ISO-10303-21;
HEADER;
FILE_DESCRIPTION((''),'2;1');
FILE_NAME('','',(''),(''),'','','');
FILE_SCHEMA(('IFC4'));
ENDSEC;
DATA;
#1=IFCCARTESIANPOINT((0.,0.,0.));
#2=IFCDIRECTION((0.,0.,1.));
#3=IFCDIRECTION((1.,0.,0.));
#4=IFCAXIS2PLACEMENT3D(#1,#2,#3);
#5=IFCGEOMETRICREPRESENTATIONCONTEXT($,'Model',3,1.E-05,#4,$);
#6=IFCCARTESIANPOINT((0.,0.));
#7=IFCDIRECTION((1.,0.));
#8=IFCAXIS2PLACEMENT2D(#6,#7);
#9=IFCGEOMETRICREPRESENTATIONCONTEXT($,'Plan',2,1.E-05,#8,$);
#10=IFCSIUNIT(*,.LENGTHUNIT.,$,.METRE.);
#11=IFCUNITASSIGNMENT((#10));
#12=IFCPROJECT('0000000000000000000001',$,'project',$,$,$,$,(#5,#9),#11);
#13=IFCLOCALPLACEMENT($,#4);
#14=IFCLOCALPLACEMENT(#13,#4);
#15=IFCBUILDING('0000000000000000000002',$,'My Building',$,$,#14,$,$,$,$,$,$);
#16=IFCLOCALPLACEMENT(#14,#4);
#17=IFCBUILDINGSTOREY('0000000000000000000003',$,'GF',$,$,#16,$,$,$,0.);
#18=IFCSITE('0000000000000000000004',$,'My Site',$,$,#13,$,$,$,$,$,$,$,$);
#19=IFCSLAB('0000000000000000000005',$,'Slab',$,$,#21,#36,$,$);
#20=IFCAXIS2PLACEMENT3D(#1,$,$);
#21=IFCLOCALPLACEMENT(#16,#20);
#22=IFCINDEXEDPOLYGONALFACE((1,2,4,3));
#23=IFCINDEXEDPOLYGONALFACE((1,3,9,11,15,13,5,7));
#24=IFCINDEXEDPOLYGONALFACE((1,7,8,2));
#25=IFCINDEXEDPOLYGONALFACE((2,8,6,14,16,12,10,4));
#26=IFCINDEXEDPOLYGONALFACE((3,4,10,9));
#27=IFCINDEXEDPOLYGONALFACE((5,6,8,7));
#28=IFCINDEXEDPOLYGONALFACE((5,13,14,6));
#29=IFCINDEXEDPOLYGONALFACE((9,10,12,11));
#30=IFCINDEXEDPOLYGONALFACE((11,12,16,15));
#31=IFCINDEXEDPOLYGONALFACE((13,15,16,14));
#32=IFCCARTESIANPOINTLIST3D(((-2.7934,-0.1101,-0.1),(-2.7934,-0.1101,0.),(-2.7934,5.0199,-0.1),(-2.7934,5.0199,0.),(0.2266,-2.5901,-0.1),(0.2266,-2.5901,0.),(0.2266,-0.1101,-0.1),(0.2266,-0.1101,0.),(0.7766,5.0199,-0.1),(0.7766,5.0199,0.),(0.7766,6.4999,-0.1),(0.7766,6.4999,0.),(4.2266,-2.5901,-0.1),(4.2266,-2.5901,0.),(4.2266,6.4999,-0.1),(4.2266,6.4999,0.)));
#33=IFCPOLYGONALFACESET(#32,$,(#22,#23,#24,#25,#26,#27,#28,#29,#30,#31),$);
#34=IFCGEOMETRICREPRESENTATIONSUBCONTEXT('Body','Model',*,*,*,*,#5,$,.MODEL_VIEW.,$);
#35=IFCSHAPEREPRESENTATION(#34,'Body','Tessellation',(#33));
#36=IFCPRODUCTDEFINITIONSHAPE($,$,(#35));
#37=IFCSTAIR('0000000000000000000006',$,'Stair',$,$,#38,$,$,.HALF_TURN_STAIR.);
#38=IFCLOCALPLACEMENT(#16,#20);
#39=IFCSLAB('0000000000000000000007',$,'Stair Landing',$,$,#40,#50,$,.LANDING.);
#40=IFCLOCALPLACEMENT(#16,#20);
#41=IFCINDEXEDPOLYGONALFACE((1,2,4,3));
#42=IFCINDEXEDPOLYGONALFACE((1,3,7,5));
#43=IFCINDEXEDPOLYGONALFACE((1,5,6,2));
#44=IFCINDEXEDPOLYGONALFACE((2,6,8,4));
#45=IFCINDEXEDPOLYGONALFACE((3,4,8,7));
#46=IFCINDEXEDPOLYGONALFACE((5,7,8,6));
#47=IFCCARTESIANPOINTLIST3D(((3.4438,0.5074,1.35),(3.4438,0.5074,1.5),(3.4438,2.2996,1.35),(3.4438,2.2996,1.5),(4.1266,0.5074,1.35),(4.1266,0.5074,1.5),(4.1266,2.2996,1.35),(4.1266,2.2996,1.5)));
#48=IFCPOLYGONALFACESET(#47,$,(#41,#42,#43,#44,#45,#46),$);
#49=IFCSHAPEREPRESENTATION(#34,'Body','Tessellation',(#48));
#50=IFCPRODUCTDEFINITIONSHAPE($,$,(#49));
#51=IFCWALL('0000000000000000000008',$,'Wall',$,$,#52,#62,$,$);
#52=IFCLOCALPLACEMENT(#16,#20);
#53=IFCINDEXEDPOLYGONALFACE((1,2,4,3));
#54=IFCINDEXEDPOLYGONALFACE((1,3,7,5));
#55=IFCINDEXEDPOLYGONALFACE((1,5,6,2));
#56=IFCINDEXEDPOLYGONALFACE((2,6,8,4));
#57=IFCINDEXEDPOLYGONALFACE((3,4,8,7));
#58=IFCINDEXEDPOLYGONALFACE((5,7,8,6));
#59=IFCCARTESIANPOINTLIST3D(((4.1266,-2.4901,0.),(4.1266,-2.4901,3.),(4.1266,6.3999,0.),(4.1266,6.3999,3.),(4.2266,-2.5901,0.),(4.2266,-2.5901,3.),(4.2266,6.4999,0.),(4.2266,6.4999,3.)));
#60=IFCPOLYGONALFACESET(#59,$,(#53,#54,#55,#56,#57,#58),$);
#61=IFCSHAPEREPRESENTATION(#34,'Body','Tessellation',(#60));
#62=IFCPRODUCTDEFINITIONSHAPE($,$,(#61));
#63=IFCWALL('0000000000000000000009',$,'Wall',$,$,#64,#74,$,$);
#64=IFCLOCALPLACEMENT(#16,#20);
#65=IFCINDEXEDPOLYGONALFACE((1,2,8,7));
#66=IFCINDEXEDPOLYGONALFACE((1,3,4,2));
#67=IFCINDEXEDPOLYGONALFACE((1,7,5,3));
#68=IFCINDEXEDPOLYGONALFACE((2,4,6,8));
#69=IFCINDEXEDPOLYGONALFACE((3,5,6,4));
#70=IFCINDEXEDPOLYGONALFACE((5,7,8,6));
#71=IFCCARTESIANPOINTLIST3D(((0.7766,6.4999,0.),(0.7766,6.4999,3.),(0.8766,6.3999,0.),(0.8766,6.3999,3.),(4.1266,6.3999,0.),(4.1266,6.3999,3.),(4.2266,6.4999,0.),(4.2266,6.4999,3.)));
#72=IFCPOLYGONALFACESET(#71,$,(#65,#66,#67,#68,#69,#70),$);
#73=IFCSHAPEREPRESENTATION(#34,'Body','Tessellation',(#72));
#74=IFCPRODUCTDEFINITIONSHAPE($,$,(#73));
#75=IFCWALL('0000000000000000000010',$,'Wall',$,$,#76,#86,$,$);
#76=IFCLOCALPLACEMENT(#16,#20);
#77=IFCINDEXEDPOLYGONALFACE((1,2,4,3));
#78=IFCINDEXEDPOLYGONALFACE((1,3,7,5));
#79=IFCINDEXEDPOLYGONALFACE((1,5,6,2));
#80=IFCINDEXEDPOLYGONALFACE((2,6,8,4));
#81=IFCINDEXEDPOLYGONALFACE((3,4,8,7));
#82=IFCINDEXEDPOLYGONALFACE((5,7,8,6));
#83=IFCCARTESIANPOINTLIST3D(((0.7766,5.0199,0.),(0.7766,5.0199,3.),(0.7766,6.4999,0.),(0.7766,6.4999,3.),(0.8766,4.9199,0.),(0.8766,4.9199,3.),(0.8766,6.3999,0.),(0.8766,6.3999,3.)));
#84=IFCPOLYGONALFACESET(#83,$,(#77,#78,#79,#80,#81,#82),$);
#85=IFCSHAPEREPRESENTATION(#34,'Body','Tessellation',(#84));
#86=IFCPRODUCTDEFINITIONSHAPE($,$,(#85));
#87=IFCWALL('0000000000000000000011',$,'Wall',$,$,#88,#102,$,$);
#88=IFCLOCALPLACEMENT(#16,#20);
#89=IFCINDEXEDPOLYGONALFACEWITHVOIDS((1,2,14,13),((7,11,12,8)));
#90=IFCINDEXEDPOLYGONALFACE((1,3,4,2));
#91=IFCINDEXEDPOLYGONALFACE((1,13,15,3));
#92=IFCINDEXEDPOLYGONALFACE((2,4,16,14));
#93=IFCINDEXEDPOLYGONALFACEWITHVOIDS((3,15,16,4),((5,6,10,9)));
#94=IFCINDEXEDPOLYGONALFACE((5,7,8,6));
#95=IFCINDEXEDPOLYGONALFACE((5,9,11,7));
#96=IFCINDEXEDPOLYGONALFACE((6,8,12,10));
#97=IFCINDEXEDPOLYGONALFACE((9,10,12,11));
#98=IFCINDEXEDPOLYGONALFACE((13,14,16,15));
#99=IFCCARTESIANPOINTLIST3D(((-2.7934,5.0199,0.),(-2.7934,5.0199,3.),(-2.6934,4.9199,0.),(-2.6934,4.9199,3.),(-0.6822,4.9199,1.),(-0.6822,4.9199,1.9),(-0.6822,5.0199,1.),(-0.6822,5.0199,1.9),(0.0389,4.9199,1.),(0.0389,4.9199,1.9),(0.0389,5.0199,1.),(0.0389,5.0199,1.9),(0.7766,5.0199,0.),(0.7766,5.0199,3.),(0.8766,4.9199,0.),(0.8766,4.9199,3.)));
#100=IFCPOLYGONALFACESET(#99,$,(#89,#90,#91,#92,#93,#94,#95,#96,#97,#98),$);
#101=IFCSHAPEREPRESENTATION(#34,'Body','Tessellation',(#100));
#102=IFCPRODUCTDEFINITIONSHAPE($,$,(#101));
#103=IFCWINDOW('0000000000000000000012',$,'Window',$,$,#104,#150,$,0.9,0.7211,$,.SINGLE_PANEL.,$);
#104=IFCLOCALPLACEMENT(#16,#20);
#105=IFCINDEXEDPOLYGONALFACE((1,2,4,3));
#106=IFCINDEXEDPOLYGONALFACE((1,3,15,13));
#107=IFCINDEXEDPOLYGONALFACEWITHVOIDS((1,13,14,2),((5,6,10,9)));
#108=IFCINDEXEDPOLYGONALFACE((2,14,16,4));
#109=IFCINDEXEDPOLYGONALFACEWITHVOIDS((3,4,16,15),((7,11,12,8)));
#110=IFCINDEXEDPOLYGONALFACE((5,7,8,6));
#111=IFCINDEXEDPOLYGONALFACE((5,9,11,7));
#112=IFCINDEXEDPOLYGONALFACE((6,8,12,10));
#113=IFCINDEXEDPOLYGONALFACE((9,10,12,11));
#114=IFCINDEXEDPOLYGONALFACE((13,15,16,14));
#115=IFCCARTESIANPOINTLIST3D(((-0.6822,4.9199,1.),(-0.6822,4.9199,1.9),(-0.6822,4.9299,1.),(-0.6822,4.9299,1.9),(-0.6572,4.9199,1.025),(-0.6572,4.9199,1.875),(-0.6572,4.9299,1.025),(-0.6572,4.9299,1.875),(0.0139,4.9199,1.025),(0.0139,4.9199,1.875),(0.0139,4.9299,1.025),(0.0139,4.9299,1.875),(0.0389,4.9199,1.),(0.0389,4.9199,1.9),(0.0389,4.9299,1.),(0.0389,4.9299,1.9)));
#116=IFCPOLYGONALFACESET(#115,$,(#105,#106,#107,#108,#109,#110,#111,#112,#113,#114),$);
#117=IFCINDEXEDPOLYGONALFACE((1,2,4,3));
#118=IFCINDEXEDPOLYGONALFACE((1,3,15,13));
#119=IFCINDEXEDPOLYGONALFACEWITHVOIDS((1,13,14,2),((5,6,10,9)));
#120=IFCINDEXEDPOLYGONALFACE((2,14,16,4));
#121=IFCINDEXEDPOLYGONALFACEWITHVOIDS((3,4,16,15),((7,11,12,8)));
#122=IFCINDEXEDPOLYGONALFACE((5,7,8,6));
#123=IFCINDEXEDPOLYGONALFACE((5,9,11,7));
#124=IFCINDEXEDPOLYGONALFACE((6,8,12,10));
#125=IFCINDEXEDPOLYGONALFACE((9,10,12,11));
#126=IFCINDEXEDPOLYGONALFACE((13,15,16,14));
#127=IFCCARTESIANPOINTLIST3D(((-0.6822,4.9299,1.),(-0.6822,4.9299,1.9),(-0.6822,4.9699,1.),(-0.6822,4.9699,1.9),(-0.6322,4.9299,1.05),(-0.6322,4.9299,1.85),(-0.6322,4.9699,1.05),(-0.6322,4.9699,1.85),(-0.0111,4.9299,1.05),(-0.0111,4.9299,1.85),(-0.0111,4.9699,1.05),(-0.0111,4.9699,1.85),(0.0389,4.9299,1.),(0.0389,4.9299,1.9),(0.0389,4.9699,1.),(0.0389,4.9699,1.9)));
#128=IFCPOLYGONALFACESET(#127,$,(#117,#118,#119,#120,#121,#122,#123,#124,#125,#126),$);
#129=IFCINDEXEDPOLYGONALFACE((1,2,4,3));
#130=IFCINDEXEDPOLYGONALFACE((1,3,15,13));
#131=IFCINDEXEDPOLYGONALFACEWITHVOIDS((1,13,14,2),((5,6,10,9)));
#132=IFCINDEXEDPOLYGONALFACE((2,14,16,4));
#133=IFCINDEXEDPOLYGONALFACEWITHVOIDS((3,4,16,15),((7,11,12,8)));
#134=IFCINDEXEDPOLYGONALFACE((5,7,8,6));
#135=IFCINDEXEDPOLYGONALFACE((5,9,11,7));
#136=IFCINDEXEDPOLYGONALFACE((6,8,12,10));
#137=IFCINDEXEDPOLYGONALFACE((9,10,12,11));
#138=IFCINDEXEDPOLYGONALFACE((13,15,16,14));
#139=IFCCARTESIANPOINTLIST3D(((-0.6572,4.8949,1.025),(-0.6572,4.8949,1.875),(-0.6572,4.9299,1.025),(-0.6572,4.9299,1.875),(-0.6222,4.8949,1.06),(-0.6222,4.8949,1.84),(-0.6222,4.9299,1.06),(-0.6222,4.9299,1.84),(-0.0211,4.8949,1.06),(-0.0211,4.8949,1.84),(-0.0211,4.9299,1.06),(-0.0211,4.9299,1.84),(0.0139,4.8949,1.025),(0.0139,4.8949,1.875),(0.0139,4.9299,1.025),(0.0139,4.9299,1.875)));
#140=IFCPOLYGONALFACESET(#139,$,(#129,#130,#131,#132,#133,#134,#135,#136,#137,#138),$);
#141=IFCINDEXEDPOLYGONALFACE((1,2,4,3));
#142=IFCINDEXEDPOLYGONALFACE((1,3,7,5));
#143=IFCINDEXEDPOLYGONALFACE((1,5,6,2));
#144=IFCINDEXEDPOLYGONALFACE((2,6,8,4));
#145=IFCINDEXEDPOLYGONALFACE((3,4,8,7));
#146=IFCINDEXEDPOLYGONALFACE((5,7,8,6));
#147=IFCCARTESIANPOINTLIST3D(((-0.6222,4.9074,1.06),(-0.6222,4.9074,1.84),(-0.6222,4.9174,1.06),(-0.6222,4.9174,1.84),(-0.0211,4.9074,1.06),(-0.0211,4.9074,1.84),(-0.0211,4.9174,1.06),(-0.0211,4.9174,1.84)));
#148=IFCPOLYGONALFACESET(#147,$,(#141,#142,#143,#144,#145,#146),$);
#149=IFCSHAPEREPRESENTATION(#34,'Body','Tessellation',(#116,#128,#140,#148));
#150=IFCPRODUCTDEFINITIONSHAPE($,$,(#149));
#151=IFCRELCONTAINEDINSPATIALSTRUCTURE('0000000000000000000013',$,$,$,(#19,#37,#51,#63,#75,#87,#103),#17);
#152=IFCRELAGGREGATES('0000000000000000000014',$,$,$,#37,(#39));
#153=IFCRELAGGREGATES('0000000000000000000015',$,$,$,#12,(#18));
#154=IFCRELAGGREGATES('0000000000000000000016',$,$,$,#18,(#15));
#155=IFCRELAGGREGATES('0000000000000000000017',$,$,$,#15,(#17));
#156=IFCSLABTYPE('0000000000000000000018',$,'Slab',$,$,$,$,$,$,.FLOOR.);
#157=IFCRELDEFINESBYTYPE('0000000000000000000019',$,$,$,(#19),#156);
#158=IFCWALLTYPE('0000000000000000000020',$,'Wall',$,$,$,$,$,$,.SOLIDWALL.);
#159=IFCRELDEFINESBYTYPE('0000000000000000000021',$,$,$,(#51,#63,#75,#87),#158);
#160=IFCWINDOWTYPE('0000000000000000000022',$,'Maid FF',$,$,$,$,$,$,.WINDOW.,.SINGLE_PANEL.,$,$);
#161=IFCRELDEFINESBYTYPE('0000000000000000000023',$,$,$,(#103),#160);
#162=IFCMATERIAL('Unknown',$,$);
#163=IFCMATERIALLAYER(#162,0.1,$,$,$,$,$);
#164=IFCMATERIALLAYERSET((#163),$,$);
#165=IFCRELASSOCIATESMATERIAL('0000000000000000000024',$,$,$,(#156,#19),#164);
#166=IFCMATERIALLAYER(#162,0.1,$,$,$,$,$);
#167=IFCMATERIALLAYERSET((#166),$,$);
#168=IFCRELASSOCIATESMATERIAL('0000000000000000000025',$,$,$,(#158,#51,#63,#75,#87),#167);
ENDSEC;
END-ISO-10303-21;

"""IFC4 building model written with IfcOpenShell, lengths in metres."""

from ifc_helpers import new_model, entity, si_unit, frame, origin_with_axes, origin_2d_with_axis, place, context, subcontext, project, spatial, polyline, line, indexed_curve, outline, extrude, shape, source, transform, mapped, material, layer, layer_set, layer_usage, type_object, type_shapes, element, fill, aggregate, save


model = new_model("IFC4")

# Units and contexts
model_context = context("Model", 3, precision=1e-05, world=origin_with_axes())
plan_context = context("Plan", 2, precision=1e-05, world=origin_2d_with_axis())
body_context_1 = subcontext(model_context, "Body", "Model", "MODEL_VIEW")
body_context_2 = subcontext(plan_context, "Body", "Plan", "PLAN_VIEW")
ifc_project = project(units=[si_unit("LENGTHUNIT", "METRE")], contexts=[model_context, plan_context])

# Site, building, storey
site_placement = place(None, origin_with_axes())
site = spatial("IfcSite", under=ifc_project, at=site_placement, Name="My Site")
building_placement = place(site_placement, origin_with_axes())
building = spatial("IfcBuilding", under=site, at=building_placement, Name="My Building")
storey_placement = place(building_placement, origin_with_axes())
storey = spatial("IfcBuildingStorey", under=building, at=storey_placement, Name="GF", Elevation=0.0)

# Slab
ifc_material = material(Name="Unknown")
ifc_layer_1 = layer(ifc_material, 0.1)
ifc_layer_set_1 = layer_set([ifc_layer_1])
ifc_layer_usage_1 = layer_usage(ifc_layer_set_1, "AXIS3", "POSITIVE", -0.1)
slab_type = type_object("IfcSlabType", Name="Slab", PredefinedType="FLOOR", material=ifc_layer_set_1)
slab_1_placement = place(storey_placement, frame((4.2266, -2.5901, 0.0), z_axis=(0.0, 0.0, 1.0), x_axis=(1.0, 0.0, 0.0)))
element("IfcSlab", 1, at=slab_1_placement, inside=storey, type_object=slab_type, material=ifc_layer_usage_1, Name="Slab", context=body_context_1, shape_type="SweptSolid", body=[
    extrude(outline(indexed_curve([(0.0, 0.0), (0.0, 9.09), (-3.45, 9.09), (-3.45, 7.61), (-7.02, 7.61), (-7.02, 2.48), (-4.0, 2.48), (-4.0, 0.0), (0.0, 0.0)])), frame((0.0, 0.0, -0.1), z_axis=(0.0, 0.0, 1.0), x_axis=(1.0, 0.0, 0.0)), (0.0, 0.0, 1.0), 0.1),
])

# Stair, slab
stair_placement = place(storey_placement, origin_with_axes())
stair = element("IfcStair", 2, at=stair_placement, inside=storey, Name="Stair", PredefinedType="HALF_TURN_STAIR")
slab_2_placement = place(stair_placement, frame((0.0, 0.0, 1.5), z_axis=(0.0, 0.0, 1.0), x_axis=(1.0, 0.0, 0.0)))
slab_2 = element("IfcSlab", 3, at=slab_2_placement, Name="Stair Landing", PredefinedType="LANDING", context=body_context_1, shape_type="SweptSolid", body=[
    extrude(outline(polyline([(3.4438, 0.5074), (4.1266, 0.5074), (4.1266, 2.2996), (3.4438, 2.2996), (3.4438, 0.5074)])), frame((0.0, 0.0, -0.15), z_axis=(0.0, 0.0, 1.0), x_axis=(1.0, 0.0, 0.0)), (0.0, 0.0, 1.0), 0.15),
])

# Shared definitions
ifc_layer_2 = layer(ifc_material, 0.1)
ifc_layer_set_2 = layer_set([ifc_layer_2])
wall_type = type_object("IfcWallType", Name="Wall", PredefinedType="SOLIDWALL", material=ifc_layer_set_2)

# Walls
ifc_layer_usage_2 = layer_usage(ifc_layer_set_2, "AXIS2", "POSITIVE", 0.0)
wall_1_placement = place(storey_placement, frame((4.2266, -2.5901, 0.0), z_axis=(0.0, 0.0, 1.0), x_axis=(0.0, 1.0, 0.0)))
element("IfcWall", 4, at=wall_1_placement, inside=storey, type_object=wall_type, material=ifc_layer_usage_2, Name="Wall", context=body_context_1, shape_type="SweptSolid", body=[
    extrude(outline(indexed_curve([(0.0, 0.0), (0.1, 0.1), (8.99, 0.1), (9.09, 0.0)], segments=[line(1, 2, 3, 4, 1)])), origin_with_axes(), (0.0, 0.0, 1.0), 3.0),
])
ifc_layer_usage_3 = layer_usage(ifc_layer_set_2, "AXIS2", "POSITIVE", 0.0)
wall_2_placement = place(storey_placement, frame((4.2266, 6.4999, 0.0), z_axis=(0.0, 0.0, 1.0), x_axis=(-1.0, 0.0, 0.0)))
element("IfcWall", 5, at=wall_2_placement, inside=storey, type_object=wall_type, material=ifc_layer_usage_3, Name="Wall", context=body_context_1, shape_type="SweptSolid", body=[
    extrude(outline(indexed_curve([(0.0, 0.0), (0.1, 0.1), (3.35, 0.1), (3.45, 0.0)], segments=[line(1, 2, 3, 4, 1)])), origin_with_axes(), (0.0, 0.0, 1.0), 3.0),
])
ifc_layer_usage_4 = layer_usage(ifc_layer_set_2, "AXIS2", "POSITIVE", 0.0)
wall_3_placement = place(storey_placement, frame((0.7766, 6.4999, 0.0), z_axis=(0.0, 0.0, 1.0), x_axis=(0.0, -1.0, 0.0)))
element("IfcWall", 6, at=wall_3_placement, inside=storey, type_object=wall_type, material=ifc_layer_usage_4, Name="Wall", context=body_context_1, shape_type="SweptSolid", body=[
    extrude(outline(indexed_curve([(0.0, 0.0), (0.1, 0.1), (1.58, 0.1), (1.48, 0.0)], segments=[line(1, 2, 3, 4, 1)])), origin_with_axes(), (0.0, 0.0, 1.0), 3.0),
])

# Wall, opening, window
ifc_layer_usage_5 = layer_usage(ifc_layer_set_2, "AXIS2", "POSITIVE", 0.0)
wall_4_placement = place(storey_placement, frame((0.7766, 5.0199, 0.0), z_axis=(0.0, 0.0, 1.0), x_axis=(-1.0, 0.0, 0.0)))
wall_4 = element("IfcWall", 7, at=wall_4_placement, inside=storey, type_object=wall_type, material=ifc_layer_usage_5, Name="Wall", context=body_context_1, shape_type="SweptSolid", body=[
    extrude(outline(indexed_curve([(0.0, 0.0), (-0.1, 0.1), (3.47, 0.1), (3.57, 0.0)], segments=[line(1, 2, 3, 4, 1)])), origin_with_axes(), (0.0, 0.0, 1.0), 3.0),
])
shared_shape_1 = source(origin_with_axes(), body_context_1, "Body", "SweptSolid", [
    extrude(outline(indexed_curve([(0.0, 0.0), (0.7211, 0.0), (0.7211, 0.9), (0.0, 0.9)], segments=[line(1, 2, 3, 4, 1)])), frame((0.0, -0.6, 0.0), z_axis=(0.0, -1.0, 0.0), x_axis=(1.0, 0.0, 0.0)), (0.0, 0.0, -1.0), 1.2),
])
opening_1_placement = place(wall_4_placement, frame((0.7377, 0.0, 1.0), z_axis=(0.0, 0.0, 1.0), x_axis=(1.0, 0.0, 0.0)))
opening_1 = element("IfcOpeningElement", 8, at=opening_1_placement, cuts=wall_4, PredefinedType="OPENING", context=body_context_1, shape_type="MappedRepresentation", body=[
    mapped(shared_shape_1, transform((0.0, 0.0, 0.0), x_axis=(1.0, 0.0, 0.0), y_axis=(0.0, 1.0, 0.0), z_axis=(0.0, 0.0, 1.0), scale=1.0)),
])
window_type_1 = type_object("IfcWindowType", Name="Maid FF", PartitioningType="SINGLE_PANEL", PredefinedType="WINDOW")
shared_shape_2 = source(origin_with_axes(), body_context_1, "Body", "SweptSolid", [
    extrude(outline(indexed_curve([(0.0, 0.0), (0.7211, 0.0), (0.7211, 0.9), (0.0, 0.9)], segments=[line(1, 2, 3, 4, 1)]), holes=[indexed_curve([(0.025, 0.025), (0.6961, 0.025), (0.6961, 0.875), (0.025, 0.875)], segments=[line(1, 2, 3, 4, 1)])]), frame((0.0, 0.09, 0.0), z_axis=(0.0, -1.0, 0.0), x_axis=(1.0, 0.0, 0.0)), (0.0, 0.0, -1.0), 0.01),
    extrude(outline(indexed_curve([(0.0, 0.0), (0.7211, 0.0), (0.7211, 0.9), (0.0, 0.9)], segments=[line(1, 2, 3, 4, 1)]), holes=[indexed_curve([(0.05, 0.05), (0.6711, 0.05), (0.6711, 0.85), (0.05, 0.85)], segments=[line(1, 2, 3, 4, 1)])]), frame((0.0, 0.05, 0.0), z_axis=(0.0, -1.0, 0.0), x_axis=(1.0, 0.0, 0.0)), (0.0, 0.0, -1.0), 0.04),
    extrude(outline(indexed_curve([(0.0, 0.0), (0.6711, 0.0), (0.6711, 0.85), (0.0, 0.85)], segments=[line(1, 2, 3, 4, 1)]), holes=[indexed_curve([(0.035, 0.035), (0.6361, 0.035), (0.6361, 0.815), (0.035, 0.815)], segments=[line(1, 2, 3, 4, 1)])]), frame((0.025, 0.09, 0.025), z_axis=(0.0, -1.0, 0.0), x_axis=(1.0, 0.0, 0.0)), (0.0, 0.0, -1.0), 0.035),
    extrude(outline(indexed_curve([(0.035, 0.035), (0.6361, 0.035), (0.6361, 0.815), (0.035, 0.815)], segments=[line(1, 2, 3, 4, 1)])), frame((0.025, 0.1025, 0.025), z_axis=(0.0, -1.0, 0.0), x_axis=(1.0, 0.0, 0.0)), (0.0, 0.0, -1.0), 0.01),
])
shared_shape_3 = source(origin_with_axes(), body_context_2, "Body", "Curve2D", [
    entity("IfcIndexedPolyCurve", entity("IfcCartesianPointList2D", [[0.05, 0.05], [0.6711, 0.05]])),
    entity("IfcIndexedPolyCurve", entity("IfcCartesianPointList2D", [[0.0, 0.1], [0.025, 0.1], [0.025, 0.09], [0.05, 0.09], [0.05, 0.05], [0.0, 0.05]]), [entity("IfcLineIndex", [1, 2, 3, 4, 5, 6, 1])]),
    entity("IfcIndexedPolyCurve", entity("IfcCartesianPointList2D", [[0.7211, 0.1], [0.6961, 0.1], [0.6961, 0.09], [0.6711, 0.09], [0.6711, 0.05], [0.7211, 0.05]]), [entity("IfcLineIndex", [1, 2, 3, 4, 5, 6, 1])]),
    entity("IfcIndexedPolyCurve", entity("IfcCartesianPointList2D", [[0.025, 0.09], [0.06, 0.09], [0.06, 0.125], [0.025, 0.125]]), [entity("IfcLineIndex", [1, 2, 3, 4, 1])]),
    entity("IfcIndexedPolyCurve", entity("IfcCartesianPointList2D", [[0.6961, 0.09], [0.6611, 0.09], [0.6611, 0.125], [0.6961, 0.125]]), [entity("IfcLineIndex", [1, 2, 3, 4, 1])]),
    entity("IfcIndexedPolyCurve", entity("IfcCartesianPointList2D", [[0.06, 0.09], [0.6611, 0.09]])),
    entity("IfcIndexedPolyCurve", entity("IfcCartesianPointList2D", [[0.06, 0.125], [0.6611, 0.125]])),
    entity("IfcIndexedPolyCurve", entity("IfcCartesianPointList2D", [[0.06, 0.1075], [0.6611, 0.1075]])),
])
type_shapes(window_type_1, [shared_shape_2, shared_shape_3])
window_1_placement = place(opening_1_placement, frame((0.0, 0.0, 0.0), z_axis=(0.0, 0.0, 1.0), x_axis=(1.0, 0.0, 0.0)))
window_1 = element("IfcWindow", 9, at=window_1_placement, inside=storey, type_object=window_type_1, Name="Window", OverallHeight=0.9, OverallWidth=0.7211, PartitioningType="SINGLE_PANEL", shapes=[
    shape(body_context_1, "Body", "MappedRepresentation", [mapped(shared_shape_2, transform((0.0, 0.0, 0.0), x_axis=(1.0, 0.0, 0.0), y_axis=(0.0, 1.0, 0.0), z_axis=(0.0, 0.0, 1.0), scale=1.0))]),
    shape(body_context_2, "Body", "MappedRepresentation", [mapped(shared_shape_3, transform((0.0, 0.0, 0.0), x_axis=(1.0, 0.0, 0.0), y_axis=(0.0, 1.0, 0.0), z_axis=(0.0, 0.0, 1.0), scale=1.0))]),
])
fill(opening_1, window_1)

aggregate(stair, [slab_2])

save(model, "model.ifc")
